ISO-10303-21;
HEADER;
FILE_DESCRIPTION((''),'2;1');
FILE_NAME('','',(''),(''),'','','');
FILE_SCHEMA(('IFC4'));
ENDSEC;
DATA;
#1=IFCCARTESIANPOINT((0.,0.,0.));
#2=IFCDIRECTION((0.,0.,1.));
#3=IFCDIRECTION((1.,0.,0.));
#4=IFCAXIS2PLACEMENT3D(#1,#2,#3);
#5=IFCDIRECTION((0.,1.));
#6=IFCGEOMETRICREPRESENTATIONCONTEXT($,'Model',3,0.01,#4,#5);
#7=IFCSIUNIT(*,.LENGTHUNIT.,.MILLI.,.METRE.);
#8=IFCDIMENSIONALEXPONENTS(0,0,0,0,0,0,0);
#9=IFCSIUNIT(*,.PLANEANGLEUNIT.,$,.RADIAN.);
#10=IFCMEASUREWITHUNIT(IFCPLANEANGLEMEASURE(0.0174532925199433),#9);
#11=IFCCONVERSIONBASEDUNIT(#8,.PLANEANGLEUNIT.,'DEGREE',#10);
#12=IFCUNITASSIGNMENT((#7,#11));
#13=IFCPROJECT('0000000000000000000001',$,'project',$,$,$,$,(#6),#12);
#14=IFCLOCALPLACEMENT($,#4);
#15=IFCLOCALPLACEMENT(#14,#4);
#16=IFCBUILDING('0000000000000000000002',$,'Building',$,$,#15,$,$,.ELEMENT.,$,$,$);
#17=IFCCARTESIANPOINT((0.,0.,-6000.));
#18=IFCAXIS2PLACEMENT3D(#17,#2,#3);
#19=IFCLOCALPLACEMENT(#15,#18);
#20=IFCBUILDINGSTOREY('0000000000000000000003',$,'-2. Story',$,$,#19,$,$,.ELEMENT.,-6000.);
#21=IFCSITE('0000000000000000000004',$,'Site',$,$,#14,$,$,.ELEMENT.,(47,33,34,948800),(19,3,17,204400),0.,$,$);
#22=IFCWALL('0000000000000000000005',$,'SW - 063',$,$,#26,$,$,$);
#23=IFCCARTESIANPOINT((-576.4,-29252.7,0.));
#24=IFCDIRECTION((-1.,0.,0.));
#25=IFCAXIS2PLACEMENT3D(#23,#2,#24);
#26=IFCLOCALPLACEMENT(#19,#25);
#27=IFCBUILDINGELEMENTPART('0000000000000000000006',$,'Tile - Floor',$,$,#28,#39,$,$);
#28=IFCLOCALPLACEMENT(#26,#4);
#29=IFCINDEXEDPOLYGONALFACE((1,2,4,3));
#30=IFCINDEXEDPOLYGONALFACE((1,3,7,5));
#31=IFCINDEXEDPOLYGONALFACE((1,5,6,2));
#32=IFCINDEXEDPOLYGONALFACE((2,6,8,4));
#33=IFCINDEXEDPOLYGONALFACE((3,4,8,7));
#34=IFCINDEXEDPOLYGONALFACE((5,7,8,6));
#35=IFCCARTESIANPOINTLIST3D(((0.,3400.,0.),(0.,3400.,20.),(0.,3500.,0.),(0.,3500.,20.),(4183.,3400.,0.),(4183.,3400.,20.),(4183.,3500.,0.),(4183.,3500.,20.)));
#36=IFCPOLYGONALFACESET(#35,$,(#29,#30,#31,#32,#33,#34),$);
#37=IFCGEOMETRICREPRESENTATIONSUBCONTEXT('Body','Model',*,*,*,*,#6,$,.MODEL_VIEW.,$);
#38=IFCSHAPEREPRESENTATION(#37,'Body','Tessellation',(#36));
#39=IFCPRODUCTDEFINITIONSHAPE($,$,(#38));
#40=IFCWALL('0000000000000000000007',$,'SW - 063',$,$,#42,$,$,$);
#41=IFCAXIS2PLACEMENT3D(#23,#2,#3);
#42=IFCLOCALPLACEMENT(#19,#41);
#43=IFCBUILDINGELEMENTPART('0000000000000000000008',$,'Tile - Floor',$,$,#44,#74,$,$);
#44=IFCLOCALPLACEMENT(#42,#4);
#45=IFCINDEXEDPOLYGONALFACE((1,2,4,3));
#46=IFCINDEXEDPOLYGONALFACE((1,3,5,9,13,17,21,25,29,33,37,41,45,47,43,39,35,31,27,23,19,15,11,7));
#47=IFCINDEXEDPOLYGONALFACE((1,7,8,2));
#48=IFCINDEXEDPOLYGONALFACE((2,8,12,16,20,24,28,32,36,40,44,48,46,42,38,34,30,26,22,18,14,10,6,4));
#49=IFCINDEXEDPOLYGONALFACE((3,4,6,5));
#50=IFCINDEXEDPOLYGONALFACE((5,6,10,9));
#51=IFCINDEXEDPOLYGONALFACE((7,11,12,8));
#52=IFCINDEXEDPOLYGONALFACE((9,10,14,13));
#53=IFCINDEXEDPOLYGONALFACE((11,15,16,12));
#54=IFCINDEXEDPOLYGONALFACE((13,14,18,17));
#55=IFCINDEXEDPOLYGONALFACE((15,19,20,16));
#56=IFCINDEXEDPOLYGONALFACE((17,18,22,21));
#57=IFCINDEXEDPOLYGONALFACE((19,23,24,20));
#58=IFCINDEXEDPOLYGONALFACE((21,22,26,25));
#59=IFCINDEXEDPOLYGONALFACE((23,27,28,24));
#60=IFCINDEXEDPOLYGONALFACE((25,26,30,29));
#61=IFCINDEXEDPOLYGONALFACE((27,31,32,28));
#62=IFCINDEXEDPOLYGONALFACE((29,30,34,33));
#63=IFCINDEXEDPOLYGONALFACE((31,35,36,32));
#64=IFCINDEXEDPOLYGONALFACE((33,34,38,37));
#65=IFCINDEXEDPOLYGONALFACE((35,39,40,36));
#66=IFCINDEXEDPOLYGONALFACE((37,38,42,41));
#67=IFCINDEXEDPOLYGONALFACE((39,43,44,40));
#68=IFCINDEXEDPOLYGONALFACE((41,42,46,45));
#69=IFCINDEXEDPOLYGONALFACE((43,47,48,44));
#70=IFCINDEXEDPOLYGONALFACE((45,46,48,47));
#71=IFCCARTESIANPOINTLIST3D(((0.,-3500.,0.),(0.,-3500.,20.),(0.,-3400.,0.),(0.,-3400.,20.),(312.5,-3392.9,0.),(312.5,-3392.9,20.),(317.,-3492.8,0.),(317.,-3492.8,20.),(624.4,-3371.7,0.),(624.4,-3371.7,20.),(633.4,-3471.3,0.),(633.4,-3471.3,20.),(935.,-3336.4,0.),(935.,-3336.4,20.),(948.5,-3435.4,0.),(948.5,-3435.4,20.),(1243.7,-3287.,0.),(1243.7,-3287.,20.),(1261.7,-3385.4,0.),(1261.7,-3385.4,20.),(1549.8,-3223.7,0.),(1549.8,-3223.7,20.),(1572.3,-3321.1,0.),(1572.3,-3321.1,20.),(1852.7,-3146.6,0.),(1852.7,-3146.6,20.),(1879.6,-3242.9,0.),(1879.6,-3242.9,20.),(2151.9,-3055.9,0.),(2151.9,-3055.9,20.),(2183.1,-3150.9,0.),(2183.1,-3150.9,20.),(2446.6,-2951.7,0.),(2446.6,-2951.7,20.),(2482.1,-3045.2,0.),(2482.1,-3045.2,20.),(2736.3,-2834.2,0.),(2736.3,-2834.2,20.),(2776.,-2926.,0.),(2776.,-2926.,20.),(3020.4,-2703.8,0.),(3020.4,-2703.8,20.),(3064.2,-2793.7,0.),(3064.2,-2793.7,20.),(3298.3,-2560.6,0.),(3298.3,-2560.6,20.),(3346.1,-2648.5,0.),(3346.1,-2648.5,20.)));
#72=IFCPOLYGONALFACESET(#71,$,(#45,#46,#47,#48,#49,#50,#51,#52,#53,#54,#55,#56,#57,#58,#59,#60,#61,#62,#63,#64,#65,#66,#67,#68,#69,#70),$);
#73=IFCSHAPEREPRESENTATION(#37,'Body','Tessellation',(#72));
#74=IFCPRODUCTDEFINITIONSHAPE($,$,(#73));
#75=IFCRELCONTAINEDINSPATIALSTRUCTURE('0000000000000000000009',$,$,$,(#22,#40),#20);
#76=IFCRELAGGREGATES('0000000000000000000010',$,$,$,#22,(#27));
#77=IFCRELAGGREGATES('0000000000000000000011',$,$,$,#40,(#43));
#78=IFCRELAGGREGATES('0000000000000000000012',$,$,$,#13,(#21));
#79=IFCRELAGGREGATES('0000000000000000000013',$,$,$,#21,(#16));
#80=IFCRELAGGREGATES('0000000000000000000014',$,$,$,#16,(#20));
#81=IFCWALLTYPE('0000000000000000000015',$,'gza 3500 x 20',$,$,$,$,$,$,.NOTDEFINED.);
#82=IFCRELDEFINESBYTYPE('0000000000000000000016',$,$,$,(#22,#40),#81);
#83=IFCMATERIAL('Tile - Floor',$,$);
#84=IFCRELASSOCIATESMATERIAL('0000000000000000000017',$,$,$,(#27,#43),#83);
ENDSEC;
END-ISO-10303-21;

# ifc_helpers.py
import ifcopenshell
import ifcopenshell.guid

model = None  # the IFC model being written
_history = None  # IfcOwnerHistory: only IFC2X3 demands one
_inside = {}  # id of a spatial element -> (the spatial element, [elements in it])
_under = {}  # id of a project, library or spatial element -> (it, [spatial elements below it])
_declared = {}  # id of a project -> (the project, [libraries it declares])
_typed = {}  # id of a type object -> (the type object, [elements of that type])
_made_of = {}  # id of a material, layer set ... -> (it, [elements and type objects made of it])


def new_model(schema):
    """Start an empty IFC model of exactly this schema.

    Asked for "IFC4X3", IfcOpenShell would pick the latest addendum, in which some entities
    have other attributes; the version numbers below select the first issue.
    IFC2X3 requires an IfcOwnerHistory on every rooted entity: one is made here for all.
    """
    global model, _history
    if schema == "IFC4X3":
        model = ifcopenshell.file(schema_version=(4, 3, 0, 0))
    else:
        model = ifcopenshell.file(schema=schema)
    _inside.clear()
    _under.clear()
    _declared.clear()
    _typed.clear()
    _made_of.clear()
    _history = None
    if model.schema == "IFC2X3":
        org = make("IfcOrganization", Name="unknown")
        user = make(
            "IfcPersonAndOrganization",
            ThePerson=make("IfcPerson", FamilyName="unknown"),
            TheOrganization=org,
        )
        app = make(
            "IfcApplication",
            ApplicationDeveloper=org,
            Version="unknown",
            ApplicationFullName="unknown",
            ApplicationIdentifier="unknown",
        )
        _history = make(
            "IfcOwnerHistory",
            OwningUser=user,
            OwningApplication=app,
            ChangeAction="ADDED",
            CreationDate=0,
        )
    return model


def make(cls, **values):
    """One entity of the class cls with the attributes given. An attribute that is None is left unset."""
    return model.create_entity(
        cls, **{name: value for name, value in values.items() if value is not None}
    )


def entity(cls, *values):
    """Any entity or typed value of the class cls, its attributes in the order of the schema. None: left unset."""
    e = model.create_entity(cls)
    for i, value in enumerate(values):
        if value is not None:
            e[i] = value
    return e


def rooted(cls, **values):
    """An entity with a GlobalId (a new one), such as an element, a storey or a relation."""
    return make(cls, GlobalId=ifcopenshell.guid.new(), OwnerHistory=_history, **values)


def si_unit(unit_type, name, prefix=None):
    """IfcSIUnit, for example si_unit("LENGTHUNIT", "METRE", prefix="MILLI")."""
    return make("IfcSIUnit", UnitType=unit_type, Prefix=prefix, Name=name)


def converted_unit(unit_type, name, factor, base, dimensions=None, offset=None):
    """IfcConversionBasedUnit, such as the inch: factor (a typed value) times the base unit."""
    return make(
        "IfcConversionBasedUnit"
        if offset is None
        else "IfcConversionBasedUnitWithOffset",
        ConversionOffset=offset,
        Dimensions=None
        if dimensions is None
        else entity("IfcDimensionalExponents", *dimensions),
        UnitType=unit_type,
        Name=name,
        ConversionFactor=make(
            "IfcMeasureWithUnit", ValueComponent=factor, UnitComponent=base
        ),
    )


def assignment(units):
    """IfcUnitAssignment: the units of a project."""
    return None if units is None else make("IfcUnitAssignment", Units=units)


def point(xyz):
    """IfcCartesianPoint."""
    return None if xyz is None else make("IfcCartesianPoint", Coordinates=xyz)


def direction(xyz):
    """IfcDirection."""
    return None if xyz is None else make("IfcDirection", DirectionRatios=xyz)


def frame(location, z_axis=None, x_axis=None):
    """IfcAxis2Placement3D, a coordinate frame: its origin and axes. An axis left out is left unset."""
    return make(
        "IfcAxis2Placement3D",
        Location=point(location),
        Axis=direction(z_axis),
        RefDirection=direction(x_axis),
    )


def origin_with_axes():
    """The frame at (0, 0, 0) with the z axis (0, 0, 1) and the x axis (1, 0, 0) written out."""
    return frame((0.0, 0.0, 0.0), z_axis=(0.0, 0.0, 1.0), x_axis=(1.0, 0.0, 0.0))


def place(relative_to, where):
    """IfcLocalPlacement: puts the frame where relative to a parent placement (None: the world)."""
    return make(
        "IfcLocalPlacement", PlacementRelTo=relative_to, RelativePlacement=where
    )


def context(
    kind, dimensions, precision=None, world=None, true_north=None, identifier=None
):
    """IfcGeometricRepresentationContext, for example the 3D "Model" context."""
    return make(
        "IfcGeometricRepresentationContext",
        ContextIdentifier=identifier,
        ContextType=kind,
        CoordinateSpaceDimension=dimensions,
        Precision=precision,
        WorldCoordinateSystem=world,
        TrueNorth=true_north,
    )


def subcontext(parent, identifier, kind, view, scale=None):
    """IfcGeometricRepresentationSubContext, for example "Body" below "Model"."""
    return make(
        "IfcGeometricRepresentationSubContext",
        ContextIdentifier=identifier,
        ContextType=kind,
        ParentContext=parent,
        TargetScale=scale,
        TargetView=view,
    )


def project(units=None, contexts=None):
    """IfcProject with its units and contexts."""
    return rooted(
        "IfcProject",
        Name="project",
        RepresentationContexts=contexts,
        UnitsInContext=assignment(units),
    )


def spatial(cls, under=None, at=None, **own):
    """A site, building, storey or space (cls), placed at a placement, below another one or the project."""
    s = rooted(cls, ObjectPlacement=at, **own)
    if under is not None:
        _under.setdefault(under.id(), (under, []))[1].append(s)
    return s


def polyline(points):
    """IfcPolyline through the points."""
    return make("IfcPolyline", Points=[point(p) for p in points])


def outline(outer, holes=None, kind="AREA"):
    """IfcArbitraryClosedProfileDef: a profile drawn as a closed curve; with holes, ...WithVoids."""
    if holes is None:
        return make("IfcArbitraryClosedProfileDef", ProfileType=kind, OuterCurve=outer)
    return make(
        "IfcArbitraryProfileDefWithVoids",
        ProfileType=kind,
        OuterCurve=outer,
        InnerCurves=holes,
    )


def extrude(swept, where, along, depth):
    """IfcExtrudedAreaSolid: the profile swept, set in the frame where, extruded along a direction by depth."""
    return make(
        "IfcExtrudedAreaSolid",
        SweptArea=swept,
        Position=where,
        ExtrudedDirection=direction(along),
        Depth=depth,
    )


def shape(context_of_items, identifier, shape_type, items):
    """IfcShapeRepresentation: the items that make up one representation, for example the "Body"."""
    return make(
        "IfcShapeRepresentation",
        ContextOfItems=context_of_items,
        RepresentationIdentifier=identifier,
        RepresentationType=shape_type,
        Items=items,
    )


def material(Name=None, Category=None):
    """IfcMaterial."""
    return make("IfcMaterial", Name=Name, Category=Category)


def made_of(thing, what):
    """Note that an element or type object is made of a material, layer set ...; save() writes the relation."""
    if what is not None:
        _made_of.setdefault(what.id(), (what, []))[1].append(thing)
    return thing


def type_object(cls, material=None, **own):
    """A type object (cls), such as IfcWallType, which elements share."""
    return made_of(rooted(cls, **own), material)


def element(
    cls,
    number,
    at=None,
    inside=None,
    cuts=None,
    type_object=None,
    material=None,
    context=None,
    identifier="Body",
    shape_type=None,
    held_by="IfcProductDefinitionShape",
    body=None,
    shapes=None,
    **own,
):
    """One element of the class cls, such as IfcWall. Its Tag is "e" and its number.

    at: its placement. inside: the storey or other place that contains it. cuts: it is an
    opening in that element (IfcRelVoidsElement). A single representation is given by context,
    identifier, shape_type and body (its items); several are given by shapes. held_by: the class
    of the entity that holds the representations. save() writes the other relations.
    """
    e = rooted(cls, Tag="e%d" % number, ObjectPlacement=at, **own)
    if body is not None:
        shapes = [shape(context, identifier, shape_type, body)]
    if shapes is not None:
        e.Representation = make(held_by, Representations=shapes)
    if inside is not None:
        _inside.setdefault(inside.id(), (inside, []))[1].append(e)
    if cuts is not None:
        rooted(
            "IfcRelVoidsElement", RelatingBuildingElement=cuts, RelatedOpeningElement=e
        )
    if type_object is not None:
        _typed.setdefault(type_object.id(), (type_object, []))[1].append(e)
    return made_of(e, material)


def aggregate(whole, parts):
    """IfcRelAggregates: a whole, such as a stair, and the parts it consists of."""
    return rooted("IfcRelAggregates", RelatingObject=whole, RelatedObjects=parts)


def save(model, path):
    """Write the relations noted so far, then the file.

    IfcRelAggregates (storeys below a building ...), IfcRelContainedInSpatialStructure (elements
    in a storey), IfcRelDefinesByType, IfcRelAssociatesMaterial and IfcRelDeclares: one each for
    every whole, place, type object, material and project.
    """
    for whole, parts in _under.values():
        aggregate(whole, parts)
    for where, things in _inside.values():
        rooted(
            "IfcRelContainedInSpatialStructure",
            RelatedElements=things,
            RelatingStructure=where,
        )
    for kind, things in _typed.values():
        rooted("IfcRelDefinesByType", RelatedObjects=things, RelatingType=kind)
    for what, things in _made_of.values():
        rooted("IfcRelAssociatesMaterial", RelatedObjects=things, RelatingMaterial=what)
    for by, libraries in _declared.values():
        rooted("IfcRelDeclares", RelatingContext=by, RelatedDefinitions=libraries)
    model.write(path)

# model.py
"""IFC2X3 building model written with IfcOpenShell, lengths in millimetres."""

from ifc_helpers import new_model, entity, si_unit, converted_unit, direction, frame, origin_with_axes, place, context, subcontext, project, spatial, polyline, outline, extrude, material, type_object, element, aggregate, save


model = new_model("IFC2X3")

# Units and contexts
model_context = context("Model", 3, precision=0.01, world=origin_with_axes(), true_north=direction((0.0, 1.0)))
body_context = subcontext(model_context, "Body", "Model", "MODEL_VIEW")
ifc_project = project(units=[si_unit("LENGTHUNIT", "METRE", prefix="MILLI"), converted_unit("PLANEANGLEUNIT", "DEGREE", entity("IfcPlaneAngleMeasure", 0.0174532925199433), si_unit("PLANEANGLEUNIT", "RADIAN"), dimensions=[0, 0, 0, 0, 0, 0, 0])], contexts=[model_context])

# Site, building, storey
site_placement = place(None, origin_with_axes())
site = spatial("IfcSite", under=ifc_project, at=site_placement, Name="Site", CompositionType="ELEMENT", RefLatitude=(47, 33, 34, 948800), RefLongitude=(19, 3, 17, 204400), RefElevation=0.0)
building_placement = place(site_placement, origin_with_axes())
building = spatial("IfcBuilding", under=site, at=building_placement, Name="Building", CompositionType="ELEMENT")
storey_placement = place(building_placement, frame((0.0, 0.0, -6000.0), z_axis=(0.0, 0.0, 1.0), x_axis=(1.0, 0.0, 0.0)))
storey = spatial("IfcBuildingStorey", under=building, at=storey_placement, Name="-2. Story", CompositionType="ELEMENT", Elevation=-6000.0)

# Walls, building element parts
wall_type_1 = type_object("IfcWallType", Name="gza 3500 x 20", PredefinedType="NOTDEFINED")
wall_1_placement = place(storey_placement, frame((-576.4, -29252.7, 0.0), z_axis=(0.0, 0.0, 1.0), x_axis=(-1.0, 0.0, 0.0)))
wall_1 = element("IfcWall", 1, at=wall_1_placement, inside=storey, type_object=wall_type_1, Name="SW - 063")
ifc_material_1 = material(Name="Tile - Floor")
building_element_part_1_placement = place(wall_1_placement, origin_with_axes())
building_element_part_1 = element("IfcBuildingElementPart", 2, at=building_element_part_1_placement, material=ifc_material_1, Name="Tile - Floor", context=body_context, shape_type="SweptSolid", body=[
    extrude(outline(polyline([(3400.0, 20.0), (3400.0, 0.0), (3500.0, 0.0), (3500.0, 20.0), (3400.0, 20.0)])), frame((0.0, 0.0, 0.0), z_axis=(1.0, 0.0, 0.0), x_axis=(0.0, 1.0, 0.0)), (0.0, 0.0, 1.0), 4183.0),
])
aggregate(wall_1, [building_element_part_1])
wall_2_placement = place(storey_placement, frame((-576.4, -29252.7, 0.0), z_axis=(0.0, 0.0, 1.0), x_axis=(1.0, 0.0, 0.0)))
wall_2 = element("IfcWall", 3, at=wall_2_placement, inside=storey, type_object=wall_type_1, Name="SW - 063")
building_element_part_2_placement = place(wall_2_placement, origin_with_axes())
cartesian_point_1 = entity("IfcCartesianPoint", [3400.0, 20.0])
building_element_part_2 = element("IfcBuildingElementPart", 4, at=building_element_part_2_placement, material=ifc_material_1, Name="Tile - Floor", context=body_context, shape_type="SweptSolid", body=[
    entity("IfcRevolvedAreaSolid", entity("IfcArbitraryClosedProfileDef", "AREA", None, entity("IfcPolyline", [cartesian_point_1, entity("IfcCartesianPoint", [3400.0, 0.0]), entity("IfcCartesianPoint", [3500.0, 0.0]), entity("IfcCartesianPoint", [3500.0, 20.0]), cartesian_point_1])), entity("IfcAxis2Placement3D", entity("IfcCartesianPoint", [0.0, 0.0, 0.0]), entity("IfcDirection", [-1.0, 0.0, 0.0]), entity("IfcDirection", [0.0, -1.0, 0.0])), entity("IfcAxis1Placement", entity("IfcCartesianPoint", [-3500.0, 0.0, 0.0]), entity("IfcDirection", [0.0, 1.0, 0.0])), 28.555603),
])
aggregate(wall_2, [building_element_part_2])

save(model, "model.ifc")
